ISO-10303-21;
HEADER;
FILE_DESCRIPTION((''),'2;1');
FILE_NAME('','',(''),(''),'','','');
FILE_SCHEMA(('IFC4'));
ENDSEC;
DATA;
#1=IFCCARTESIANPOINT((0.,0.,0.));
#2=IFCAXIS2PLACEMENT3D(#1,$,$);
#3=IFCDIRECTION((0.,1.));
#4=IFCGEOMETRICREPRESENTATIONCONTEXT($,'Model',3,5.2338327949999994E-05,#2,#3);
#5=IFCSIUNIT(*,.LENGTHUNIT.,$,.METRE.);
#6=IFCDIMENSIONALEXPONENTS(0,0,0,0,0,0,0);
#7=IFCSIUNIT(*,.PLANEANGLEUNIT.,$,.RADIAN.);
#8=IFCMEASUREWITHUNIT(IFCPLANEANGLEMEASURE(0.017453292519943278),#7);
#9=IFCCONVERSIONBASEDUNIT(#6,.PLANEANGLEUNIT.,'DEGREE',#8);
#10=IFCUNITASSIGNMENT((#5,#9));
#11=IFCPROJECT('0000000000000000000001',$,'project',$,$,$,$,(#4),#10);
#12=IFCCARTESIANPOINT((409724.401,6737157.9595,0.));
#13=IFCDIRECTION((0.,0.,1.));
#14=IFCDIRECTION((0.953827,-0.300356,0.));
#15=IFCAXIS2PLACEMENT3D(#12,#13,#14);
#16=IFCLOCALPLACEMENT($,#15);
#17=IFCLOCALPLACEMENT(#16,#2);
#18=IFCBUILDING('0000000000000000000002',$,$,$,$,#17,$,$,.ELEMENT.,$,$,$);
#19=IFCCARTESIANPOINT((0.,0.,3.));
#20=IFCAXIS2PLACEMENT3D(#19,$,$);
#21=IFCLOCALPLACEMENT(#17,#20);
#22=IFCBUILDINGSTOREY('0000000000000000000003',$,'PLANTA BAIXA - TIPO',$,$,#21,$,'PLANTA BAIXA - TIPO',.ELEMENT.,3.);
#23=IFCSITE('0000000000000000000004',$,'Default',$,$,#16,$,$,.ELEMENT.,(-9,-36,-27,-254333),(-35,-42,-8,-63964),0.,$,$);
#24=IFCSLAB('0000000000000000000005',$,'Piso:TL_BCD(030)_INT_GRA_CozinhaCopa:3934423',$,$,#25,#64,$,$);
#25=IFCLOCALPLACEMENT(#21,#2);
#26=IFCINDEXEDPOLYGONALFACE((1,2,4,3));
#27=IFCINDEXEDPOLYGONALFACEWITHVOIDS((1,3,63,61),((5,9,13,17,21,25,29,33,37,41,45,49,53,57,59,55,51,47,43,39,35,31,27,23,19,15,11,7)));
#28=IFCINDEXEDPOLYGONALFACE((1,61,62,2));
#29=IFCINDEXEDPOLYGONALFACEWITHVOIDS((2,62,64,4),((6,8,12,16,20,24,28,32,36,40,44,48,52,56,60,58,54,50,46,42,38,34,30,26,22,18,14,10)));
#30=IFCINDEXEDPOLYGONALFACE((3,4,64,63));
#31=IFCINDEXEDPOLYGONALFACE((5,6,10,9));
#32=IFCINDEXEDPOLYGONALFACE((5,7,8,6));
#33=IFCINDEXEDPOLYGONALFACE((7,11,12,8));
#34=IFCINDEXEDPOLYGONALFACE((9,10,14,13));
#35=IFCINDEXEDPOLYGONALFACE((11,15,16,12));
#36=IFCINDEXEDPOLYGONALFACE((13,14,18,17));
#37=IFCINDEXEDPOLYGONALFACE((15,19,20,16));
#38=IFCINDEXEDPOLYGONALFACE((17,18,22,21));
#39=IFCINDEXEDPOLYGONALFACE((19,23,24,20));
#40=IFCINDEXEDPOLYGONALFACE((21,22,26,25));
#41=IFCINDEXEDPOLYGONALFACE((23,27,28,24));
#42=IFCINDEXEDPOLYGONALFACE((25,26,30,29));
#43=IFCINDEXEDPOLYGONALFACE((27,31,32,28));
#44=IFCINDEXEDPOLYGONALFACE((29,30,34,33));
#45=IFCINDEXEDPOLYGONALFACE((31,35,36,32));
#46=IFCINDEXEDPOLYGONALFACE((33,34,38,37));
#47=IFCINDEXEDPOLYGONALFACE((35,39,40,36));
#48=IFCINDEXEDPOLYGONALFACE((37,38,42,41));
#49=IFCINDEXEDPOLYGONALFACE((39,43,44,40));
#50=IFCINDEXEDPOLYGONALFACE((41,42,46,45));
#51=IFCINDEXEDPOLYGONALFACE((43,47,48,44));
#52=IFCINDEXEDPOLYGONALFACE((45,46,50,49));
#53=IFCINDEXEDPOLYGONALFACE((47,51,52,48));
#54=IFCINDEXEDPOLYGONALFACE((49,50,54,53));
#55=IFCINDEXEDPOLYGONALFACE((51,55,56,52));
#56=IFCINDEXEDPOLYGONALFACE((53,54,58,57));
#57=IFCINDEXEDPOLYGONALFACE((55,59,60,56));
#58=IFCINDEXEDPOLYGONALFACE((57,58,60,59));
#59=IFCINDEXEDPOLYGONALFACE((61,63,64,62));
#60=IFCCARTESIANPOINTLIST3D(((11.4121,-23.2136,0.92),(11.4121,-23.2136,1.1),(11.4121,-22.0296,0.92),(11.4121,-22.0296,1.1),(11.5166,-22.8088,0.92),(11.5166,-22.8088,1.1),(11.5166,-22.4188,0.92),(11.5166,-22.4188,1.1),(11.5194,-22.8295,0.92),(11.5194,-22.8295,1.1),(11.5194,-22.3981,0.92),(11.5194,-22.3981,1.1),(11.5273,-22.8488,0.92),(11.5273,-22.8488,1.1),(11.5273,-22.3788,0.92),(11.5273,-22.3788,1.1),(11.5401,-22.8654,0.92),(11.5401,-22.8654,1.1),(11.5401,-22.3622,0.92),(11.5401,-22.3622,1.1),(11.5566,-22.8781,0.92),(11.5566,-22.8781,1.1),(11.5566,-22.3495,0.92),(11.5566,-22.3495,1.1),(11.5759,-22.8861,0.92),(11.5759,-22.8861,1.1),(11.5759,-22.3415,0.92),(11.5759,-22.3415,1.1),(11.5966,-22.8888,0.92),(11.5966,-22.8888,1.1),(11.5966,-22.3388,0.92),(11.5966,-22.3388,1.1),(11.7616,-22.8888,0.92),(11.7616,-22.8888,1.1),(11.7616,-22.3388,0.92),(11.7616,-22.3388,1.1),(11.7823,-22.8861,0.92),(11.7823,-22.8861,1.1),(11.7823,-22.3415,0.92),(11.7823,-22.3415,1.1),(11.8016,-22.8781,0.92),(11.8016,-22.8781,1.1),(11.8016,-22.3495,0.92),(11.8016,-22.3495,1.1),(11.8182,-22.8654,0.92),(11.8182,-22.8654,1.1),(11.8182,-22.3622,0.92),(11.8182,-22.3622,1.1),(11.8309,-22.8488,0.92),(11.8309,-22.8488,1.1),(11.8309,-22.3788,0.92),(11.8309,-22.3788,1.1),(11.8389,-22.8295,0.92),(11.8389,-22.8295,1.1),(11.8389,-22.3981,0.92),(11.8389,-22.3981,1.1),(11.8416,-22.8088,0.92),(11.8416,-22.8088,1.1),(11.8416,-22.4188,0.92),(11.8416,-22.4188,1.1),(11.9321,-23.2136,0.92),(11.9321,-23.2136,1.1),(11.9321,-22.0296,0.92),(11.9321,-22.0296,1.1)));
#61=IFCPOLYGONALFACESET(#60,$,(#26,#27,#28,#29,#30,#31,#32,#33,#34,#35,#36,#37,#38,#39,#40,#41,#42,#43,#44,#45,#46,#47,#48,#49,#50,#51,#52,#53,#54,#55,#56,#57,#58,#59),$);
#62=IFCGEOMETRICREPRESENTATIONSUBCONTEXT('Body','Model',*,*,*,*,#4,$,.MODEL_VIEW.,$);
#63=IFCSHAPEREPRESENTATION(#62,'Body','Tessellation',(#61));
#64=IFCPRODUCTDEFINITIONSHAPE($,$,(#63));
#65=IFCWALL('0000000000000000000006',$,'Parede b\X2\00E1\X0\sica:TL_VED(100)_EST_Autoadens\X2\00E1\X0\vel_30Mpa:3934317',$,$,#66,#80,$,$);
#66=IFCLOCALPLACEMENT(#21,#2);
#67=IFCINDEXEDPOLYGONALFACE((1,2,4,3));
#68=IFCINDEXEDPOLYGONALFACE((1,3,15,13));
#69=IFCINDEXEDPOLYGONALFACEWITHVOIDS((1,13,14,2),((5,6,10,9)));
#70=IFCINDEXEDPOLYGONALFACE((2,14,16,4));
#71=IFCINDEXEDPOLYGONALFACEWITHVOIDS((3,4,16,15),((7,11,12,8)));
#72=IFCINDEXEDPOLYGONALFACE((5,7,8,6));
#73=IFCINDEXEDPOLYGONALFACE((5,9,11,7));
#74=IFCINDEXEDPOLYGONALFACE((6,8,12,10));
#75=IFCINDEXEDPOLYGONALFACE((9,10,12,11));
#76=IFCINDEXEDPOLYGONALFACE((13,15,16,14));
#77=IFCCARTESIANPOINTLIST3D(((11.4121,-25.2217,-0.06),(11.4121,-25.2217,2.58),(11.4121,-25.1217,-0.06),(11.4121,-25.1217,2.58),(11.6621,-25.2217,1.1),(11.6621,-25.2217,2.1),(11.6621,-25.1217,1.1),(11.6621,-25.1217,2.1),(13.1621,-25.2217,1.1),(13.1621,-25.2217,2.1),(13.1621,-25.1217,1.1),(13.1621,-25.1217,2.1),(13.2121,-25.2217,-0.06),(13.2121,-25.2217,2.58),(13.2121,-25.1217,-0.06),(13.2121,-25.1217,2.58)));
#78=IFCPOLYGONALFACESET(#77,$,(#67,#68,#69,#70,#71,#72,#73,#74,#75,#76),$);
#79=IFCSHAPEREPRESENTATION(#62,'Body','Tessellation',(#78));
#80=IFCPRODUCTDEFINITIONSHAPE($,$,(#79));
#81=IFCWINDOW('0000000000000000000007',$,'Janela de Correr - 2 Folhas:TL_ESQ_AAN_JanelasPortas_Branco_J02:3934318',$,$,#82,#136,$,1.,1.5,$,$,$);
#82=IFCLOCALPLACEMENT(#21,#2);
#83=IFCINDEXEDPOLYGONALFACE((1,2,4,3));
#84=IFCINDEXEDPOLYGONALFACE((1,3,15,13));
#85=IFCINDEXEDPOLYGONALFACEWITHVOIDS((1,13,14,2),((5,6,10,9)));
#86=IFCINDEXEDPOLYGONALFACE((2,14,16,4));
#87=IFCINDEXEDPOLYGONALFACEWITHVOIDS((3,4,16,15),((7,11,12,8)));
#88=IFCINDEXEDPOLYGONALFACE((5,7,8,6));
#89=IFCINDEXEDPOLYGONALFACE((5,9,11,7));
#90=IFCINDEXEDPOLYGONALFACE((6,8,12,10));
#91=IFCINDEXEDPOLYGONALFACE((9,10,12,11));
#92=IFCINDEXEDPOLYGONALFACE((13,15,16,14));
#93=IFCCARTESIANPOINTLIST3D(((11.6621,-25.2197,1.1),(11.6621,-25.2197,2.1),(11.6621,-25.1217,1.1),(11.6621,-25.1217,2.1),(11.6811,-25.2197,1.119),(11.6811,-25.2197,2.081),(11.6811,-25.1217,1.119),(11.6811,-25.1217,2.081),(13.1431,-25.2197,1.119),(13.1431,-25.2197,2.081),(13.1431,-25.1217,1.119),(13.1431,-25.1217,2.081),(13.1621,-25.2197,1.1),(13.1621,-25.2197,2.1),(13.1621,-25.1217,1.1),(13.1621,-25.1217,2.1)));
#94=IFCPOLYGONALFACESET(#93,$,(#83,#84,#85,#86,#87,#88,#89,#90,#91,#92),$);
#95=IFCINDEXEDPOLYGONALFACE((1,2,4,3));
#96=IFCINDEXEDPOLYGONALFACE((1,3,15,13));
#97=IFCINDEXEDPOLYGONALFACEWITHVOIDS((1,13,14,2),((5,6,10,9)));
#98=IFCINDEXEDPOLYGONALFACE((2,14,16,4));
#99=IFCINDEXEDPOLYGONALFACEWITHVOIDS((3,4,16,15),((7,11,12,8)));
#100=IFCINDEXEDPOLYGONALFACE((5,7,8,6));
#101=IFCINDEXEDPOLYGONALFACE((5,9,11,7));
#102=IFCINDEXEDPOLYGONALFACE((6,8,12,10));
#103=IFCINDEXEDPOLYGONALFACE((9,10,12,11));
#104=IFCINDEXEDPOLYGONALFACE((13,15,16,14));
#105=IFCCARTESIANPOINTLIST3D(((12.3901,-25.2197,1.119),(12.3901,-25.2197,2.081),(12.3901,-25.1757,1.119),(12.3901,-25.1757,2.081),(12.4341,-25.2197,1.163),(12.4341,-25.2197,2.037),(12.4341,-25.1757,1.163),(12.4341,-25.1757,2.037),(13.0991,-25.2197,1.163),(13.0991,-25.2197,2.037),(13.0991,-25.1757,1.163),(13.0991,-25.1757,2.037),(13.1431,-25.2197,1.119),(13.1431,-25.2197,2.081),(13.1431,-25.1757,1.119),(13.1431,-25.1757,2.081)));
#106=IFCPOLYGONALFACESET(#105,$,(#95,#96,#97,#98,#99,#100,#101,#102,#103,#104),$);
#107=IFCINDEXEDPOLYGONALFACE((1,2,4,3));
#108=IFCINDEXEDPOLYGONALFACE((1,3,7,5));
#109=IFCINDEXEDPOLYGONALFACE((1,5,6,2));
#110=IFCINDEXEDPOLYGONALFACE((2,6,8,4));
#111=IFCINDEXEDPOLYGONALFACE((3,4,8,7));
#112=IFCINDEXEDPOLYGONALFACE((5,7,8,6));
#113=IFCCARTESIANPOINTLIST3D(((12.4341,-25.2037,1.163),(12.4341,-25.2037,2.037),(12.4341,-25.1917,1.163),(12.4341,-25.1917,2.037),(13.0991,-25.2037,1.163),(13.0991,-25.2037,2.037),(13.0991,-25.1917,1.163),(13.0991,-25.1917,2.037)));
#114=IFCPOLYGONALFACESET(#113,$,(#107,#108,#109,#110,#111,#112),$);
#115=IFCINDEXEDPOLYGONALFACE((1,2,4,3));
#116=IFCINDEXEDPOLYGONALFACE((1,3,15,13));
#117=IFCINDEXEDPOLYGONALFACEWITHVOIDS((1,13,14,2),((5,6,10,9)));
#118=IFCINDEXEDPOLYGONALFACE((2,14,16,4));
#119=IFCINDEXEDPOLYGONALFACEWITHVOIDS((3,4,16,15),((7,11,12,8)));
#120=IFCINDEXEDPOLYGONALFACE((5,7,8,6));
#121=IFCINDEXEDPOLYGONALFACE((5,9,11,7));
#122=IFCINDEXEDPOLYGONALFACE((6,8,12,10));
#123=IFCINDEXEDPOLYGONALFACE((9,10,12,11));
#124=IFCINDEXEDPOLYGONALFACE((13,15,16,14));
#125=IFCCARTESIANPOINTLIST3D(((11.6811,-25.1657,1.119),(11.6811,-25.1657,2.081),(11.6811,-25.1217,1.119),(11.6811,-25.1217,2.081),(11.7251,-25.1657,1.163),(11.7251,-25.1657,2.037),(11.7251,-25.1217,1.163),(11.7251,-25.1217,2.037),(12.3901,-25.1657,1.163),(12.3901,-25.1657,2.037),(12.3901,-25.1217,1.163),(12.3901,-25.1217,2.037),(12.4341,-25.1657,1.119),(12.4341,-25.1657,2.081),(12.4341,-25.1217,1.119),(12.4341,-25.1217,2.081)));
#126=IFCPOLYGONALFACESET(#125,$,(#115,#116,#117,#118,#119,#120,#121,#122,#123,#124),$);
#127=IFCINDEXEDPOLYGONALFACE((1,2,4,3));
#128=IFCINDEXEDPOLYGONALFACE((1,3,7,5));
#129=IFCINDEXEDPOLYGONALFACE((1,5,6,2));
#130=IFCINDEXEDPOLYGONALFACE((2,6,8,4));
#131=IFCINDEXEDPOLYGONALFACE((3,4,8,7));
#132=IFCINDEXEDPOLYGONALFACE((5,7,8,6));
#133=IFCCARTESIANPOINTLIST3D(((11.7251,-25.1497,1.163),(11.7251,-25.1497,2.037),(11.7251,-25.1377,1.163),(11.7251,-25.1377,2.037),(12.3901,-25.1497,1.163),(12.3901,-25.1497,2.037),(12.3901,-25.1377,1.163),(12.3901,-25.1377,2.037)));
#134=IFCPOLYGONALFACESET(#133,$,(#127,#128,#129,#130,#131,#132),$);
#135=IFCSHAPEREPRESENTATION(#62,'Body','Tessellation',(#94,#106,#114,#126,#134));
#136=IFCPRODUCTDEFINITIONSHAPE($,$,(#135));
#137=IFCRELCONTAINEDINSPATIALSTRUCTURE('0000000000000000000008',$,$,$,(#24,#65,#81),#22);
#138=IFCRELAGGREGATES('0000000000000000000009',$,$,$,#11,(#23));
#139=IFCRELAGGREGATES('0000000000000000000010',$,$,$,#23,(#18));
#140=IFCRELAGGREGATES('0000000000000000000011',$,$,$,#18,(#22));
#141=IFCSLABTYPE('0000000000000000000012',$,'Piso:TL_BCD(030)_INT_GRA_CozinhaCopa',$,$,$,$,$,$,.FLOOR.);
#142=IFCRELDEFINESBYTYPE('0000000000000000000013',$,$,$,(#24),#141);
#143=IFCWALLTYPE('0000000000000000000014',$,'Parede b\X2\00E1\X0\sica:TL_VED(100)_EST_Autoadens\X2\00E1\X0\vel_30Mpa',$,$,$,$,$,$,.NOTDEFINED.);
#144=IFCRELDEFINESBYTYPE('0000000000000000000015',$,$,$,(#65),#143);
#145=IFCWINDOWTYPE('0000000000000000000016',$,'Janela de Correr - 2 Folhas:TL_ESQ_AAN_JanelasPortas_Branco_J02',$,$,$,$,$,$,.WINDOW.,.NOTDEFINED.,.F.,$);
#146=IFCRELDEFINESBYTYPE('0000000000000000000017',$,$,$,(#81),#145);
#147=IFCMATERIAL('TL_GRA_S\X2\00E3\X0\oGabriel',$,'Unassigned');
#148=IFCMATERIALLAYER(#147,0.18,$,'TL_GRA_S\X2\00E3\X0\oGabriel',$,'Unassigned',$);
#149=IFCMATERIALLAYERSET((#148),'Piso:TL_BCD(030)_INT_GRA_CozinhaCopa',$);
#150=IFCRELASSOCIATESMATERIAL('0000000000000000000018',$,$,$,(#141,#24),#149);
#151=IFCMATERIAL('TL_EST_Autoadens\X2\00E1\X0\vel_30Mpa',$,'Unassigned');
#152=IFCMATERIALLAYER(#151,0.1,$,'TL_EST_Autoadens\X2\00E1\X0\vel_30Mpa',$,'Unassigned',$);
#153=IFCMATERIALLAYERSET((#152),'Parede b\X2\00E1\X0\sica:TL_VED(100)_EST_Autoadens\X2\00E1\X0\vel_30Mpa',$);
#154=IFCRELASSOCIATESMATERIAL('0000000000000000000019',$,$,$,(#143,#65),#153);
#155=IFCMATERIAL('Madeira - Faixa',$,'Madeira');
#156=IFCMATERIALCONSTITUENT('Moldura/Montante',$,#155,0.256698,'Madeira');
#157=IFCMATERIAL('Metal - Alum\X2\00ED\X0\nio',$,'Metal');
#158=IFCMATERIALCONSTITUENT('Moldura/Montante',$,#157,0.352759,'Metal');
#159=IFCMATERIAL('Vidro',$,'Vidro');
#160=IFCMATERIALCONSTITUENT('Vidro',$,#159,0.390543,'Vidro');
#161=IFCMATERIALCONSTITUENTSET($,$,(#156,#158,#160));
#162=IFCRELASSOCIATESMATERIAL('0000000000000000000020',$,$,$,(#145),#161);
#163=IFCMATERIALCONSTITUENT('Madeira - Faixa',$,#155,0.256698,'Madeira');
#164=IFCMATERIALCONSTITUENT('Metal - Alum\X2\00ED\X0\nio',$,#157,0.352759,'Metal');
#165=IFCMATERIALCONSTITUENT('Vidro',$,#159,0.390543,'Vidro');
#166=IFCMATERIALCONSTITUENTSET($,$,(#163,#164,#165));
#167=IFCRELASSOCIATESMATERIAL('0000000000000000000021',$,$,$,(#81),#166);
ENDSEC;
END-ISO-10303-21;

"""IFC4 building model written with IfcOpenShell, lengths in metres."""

from ifc_helpers import new_model, entity, si_unit, converted_unit, direction, frame, frame_2d, origin, origin_2d_with_axis, place, context, subcontext, project, spatial, polyline, circle_curve, parameter, trimmed, segment, composite_curve, rectangle, outline, extrude, source, transform, mapped, material, layer, layer_set, layer_usage, constituent, constituent_set, type_object, type_shapes, element, fill, save


model = new_model("IFC4")

# Units and contexts
model_context = context("Model", 3, precision=5.2338327949999994e-05, world=origin(), true_north=direction((0.0, 1.0)))
body_context = subcontext(model_context, "Body", "Model", "MODEL_VIEW")
ifc_project = project(units=[si_unit("LENGTHUNIT", "METRE"), converted_unit("PLANEANGLEUNIT", "DEGREE", entity("IfcPlaneAngleMeasure", 0.017453292519943278), si_unit("PLANEANGLEUNIT", "RADIAN"), dimensions=[0, 0, 0, 0, 0, 0, 0])], contexts=[model_context])

# Site, building, storey
site_placement = place(None, frame((409724.401, 6737157.9595, 0.0), z_axis=(0.0, 0.0, 1.0), x_axis=(0.953827, -0.300356, 0.0)))
site = spatial("IfcSite", under=ifc_project, at=site_placement, Name="Default", CompositionType="ELEMENT", RefLatitude=(-9, -36, -27, -254333), RefLongitude=(-35, -42, -8, -63964), RefElevation=0.0)
building_placement = place(site_placement, origin())
building = spatial("IfcBuilding", under=site, at=building_placement, CompositionType="ELEMENT")
storey_placement = place(building_placement, frame((0.0, 0.0, 3.0)))
storey = spatial("IfcBuildingStorey", under=building, at=storey_placement, Name="PLANTA BAIXA - TIPO", LongName="PLANTA BAIXA - TIPO", CompositionType="ELEMENT", Elevation=3.0)

# Slab, opening
ifc_material_1 = material(Name="TL_GRA_SãoGabriel", Category="Unassigned")
ifc_layer_1 = layer(ifc_material_1, 0.18, Name="TL_GRA_SãoGabriel", Category="Unassigned")
ifc_layer_set_1 = layer_set([ifc_layer_1], Name="Piso:TL_BCD(030)_INT_GRA_CozinhaCopa")
ifc_layer_usage_1 = layer_usage(ifc_layer_set_1, "AXIS3", "POSITIVE", 0.0)
slab_type_1 = type_object("IfcSlabType", Name="Piso:TL_BCD(030)_INT_GRA_CozinhaCopa", PredefinedType="FLOOR", material=ifc_layer_set_1)
slab_1_placement = place(storey_placement, frame((11.4121, -23.2136, 0.92)))
slab_1 = element("IfcSlab", 1, at=slab_1_placement, inside=storey, type_object=slab_type_1, material=ifc_layer_usage_1, Name="Piso:TL_BCD(030)_INT_GRA_CozinhaCopa:3934423", context=body_context, shape_type="SweptSolid", body=[
    extrude(rectangle(XDim=1.184, YDim=0.52, at=frame_2d((0.0, 0.0), x_axis=(0.0, 1.0))), frame((0.26, 0.592, 0.18), z_axis=(0.0, 0.0, -1.0), x_axis=(-1.0, 0.0, 0.0)), (0.0, 0.0, 1.0), 0.18),
])
opening_1_placement = place(slab_1_placement, frame((-11.4121, 23.2136, 0.18)))
element("IfcOpeningElement", 2, at=opening_1_placement, cuts=slab_1, PredefinedType="OPENING", context=body_context, shape_type="SweptSolid", body=[
    extrude(outline(composite_curve([segment(polyline([(-0.195, -0.1625), (0.195, -0.1625)]), True, "CONTINUOUS"), segment(trimmed(circle_curve(frame_2d((0.195, -0.0825), x_axis=(-1.0, 0.0)), 0.08), [parameter(90.0)], [parameter(180.0)], True, "PARAMETER"), True, "CONTINUOUS"), segment(polyline([(0.275, -0.0825), (0.275, 0.0825)]), True, "CONTINUOUS"), segment(trimmed(circle_curve(frame_2d((0.195, 0.0825), x_axis=(-1.0, 0.0)), 0.08), [parameter(180.0)], [parameter(270.0)], True, "PARAMETER"), True, "CONTINUOUS"), segment(polyline([(0.195, 0.1625), (-0.195, 0.1625)]), True, "CONTINUOUS"), segment(trimmed(circle_curve(frame_2d((-0.195, 0.0825), x_axis=(-1.0, 0.0)), 0.08), [parameter(270.0)], [parameter(360.0)], True, "PARAMETER"), True, "CONTINUOUS"), segment(polyline([(-0.275, 0.0825), (-0.275, -0.0825)]), True, "CONTINUOUS"), segment(trimmed(circle_curve(frame_2d((-0.195, -0.0825), x_axis=(-1.0, 0.0)), 0.08), [parameter(360.0)], [parameter(90.0)], True, "PARAMETER"), True, "CONTINUOUS")], self_intersect=False)), frame((11.6791, -22.6138, -0.21), z_axis=(0.0, 0.0, 1.0), x_axis=(0.0, -1.0, 0.0)), (0.0, 0.0, 1.0), 0.21),
])

# Wall, opening, window
ifc_material_2 = material(Name="TL_EST_Autoadensável_30Mpa", Category="Unassigned")
ifc_layer_2 = layer(ifc_material_2, 0.1, Name="TL_EST_Autoadensável_30Mpa", Category="Unassigned")
ifc_layer_set_2 = layer_set([ifc_layer_2], Name="Parede básica:TL_VED(100)_EST_Autoadensável_30Mpa")
ifc_layer_usage_2 = layer_usage(ifc_layer_set_2, "AXIS2", "NEGATIVE", 0.05)
wall_type_1 = type_object("IfcWallType", Name="Parede básica:TL_VED(100)_EST_Autoadensável_30Mpa", PredefinedType="NOTDEFINED", material=ifc_layer_set_2)
wall_1_placement = place(storey_placement, frame((13.2121, -25.1717, -0.06), z_axis=(0.0, 0.0, 1.0), x_axis=(-1.0, 0.0, 0.0)))
wall_1 = element("IfcWall", 3, at=wall_1_placement, inside=storey, type_object=wall_type_1, material=ifc_layer_usage_2, Name="Parede básica:TL_VED(100)_EST_Autoadensável_30Mpa:3934317", context=body_context, shape_type="SweptSolid", body=[
    extrude(rectangle(XDim=1.8, YDim=0.1, at=frame_2d((0.9, 0.0), x_axis=(-1.0, 0.0))), origin(), (0.0, 0.0, 1.0), 2.64),
])
opening_2_placement = place(wall_1_placement, frame((0.05, -0.05, 1.16)))
opening_2 = element("IfcOpeningElement", 4, at=opening_2_placement, cuts=wall_1, PredefinedType="OPENING", context=body_context, shape_type="SweptSolid", body=[
    extrude(rectangle(XDim=1.0, YDim=1.5, at=frame_2d((0.5, 0.75), x_axis=(-1.0, 0.0))), frame((0.0, 0.0, 0.0), z_axis=(0.0, 1.0, 0.0), x_axis=(0.0, 0.0, 1.0)), (0.0, 0.0, 1.0), 0.1),
])
ifc_material_3 = material(Name="Madeira - Faixa", Category="Madeira")
ifc_constituent_1 = constituent(ifc_material_3, Name="Madeira - Faixa", Category="Madeira", fraction=0.256698)
ifc_material_4 = material(Name="Metal - Alumínio", Category="Metal")
ifc_constituent_2 = constituent(ifc_material_4, Name="Metal - Alumínio", Category="Metal", fraction=0.352759)
ifc_material_5 = material(Name="Vidro", Category="Vidro")
ifc_constituent_3 = constituent(ifc_material_5, Name="Vidro", Category="Vidro", fraction=0.390543)
ifc_constituent_set_1 = constituent_set(constituents=[ifc_constituent_1, ifc_constituent_2, ifc_constituent_3])
ifc_constituent_4 = constituent(ifc_material_3, Name="Moldura/Montante", Category="Madeira", fraction=0.256698)
ifc_constituent_5 = constituent(ifc_material_4, Name="Moldura/Montante", Category="Metal", fraction=0.352759)
ifc_constituent_6 = constituent(ifc_material_5, Name="Vidro", Category="Vidro", fraction=0.390543)
ifc_constituent_set_2 = constituent_set(constituents=[ifc_constituent_4, ifc_constituent_5, ifc_constituent_6])
window_type_1 = type_object("IfcWindowType", Name="Janela de Correr - 2 Folhas:TL_ESQ_AAN_JanelasPortas_Branco_J02", ParameterTakesPrecedence=False, PartitioningType="NOTDEFINED", PredefinedType="WINDOW", material=ifc_constituent_set_2)
shared_shape_1 = source(origin(), body_context, "Body", "SweptSolid", [
    extrude(outline(polyline([(-0.75, -0.5), (0.75, -0.5), (0.75, 0.5), (-0.75, 0.5), (-0.75, -0.5)]), holes=[polyline([(-0.731, -0.481), (-0.731, 0.481), (0.731, 0.481), (0.731, -0.481), (-0.731, -0.481)])]), frame((0.75, 0.124, 0.5), z_axis=(0.0, -1.0, 0.0), x_axis=(-1.0, 0.0, 0.0)), (0.0, 0.0, 1.0), 0.098),
    extrude(outline(polyline([(-0.3765, -0.481), (0.3765, -0.481), (0.3765, 0.481), (-0.3765, 0.481), (-0.3765, -0.481)]), holes=[polyline([(-0.3325, -0.437), (-0.3325, 0.437), (0.3325, 0.437), (0.3325, -0.437), (-0.3325, -0.437)])]), frame((0.3955, 0.124, 0.5), z_axis=(0.0, -1.0, 0.0), x_axis=(-1.0, 0.0, 0.0)), (0.0, 0.0, 1.0), 0.044),
    extrude(rectangle(XDim=0.665, YDim=0.012, at=origin_2d_with_axis()), frame((0.3955, 0.102, 0.063), z_axis=(0.0, 0.0, 1.0), x_axis=(-1.0, 0.0, 0.0)), (0.0, 0.0, 1.0), 0.874),
    extrude(outline(polyline([(-0.481, -0.3765), (0.481, -0.3765), (0.481, 0.3765), (-0.481, 0.3765), (-0.481, -0.3765)]), holes=[polyline([(-0.437, -0.3325), (-0.437, 0.3325), (0.437, 0.3325), (0.437, -0.3325), (-0.437, -0.3325)])]), frame((1.1045, 0.07, 0.5), z_axis=(0.0, -1.0, 0.0), x_axis=(0.0, 0.0, -1.0)), (0.0, 0.0, 1.0), 0.044),
    extrude(rectangle(XDim=0.665, YDim=0.012, at=origin_2d_with_axis()), frame((1.1045, 0.048, 0.063), z_axis=(0.0, 0.0, 1.0), x_axis=(-1.0, 0.0, 0.0)), (0.0, 0.0, 1.0), 0.874),
])
type_shapes(window_type_1, [shared_shape_1])
window_1_placement = place(opening_2_placement, frame((0.0, -0.026, 0.0)))
window_1 = element("IfcWindow", 5, at=window_1_placement, inside=storey, type_object=window_type_1, material=ifc_constituent_set_1, Name="Janela de Correr - 2 Folhas:TL_ESQ_AAN_JanelasPortas_Branco_J02:3934318", OverallHeight=1.0, OverallWidth=1.5, context=body_context, shape_type="MappedRepresentation", body=[
    mapped(shared_shape_1, transform((0.0, 0.0, 0.0), scale=1.0)),
])
fill(opening_2, window_1)

save(model, "model.ifc")
